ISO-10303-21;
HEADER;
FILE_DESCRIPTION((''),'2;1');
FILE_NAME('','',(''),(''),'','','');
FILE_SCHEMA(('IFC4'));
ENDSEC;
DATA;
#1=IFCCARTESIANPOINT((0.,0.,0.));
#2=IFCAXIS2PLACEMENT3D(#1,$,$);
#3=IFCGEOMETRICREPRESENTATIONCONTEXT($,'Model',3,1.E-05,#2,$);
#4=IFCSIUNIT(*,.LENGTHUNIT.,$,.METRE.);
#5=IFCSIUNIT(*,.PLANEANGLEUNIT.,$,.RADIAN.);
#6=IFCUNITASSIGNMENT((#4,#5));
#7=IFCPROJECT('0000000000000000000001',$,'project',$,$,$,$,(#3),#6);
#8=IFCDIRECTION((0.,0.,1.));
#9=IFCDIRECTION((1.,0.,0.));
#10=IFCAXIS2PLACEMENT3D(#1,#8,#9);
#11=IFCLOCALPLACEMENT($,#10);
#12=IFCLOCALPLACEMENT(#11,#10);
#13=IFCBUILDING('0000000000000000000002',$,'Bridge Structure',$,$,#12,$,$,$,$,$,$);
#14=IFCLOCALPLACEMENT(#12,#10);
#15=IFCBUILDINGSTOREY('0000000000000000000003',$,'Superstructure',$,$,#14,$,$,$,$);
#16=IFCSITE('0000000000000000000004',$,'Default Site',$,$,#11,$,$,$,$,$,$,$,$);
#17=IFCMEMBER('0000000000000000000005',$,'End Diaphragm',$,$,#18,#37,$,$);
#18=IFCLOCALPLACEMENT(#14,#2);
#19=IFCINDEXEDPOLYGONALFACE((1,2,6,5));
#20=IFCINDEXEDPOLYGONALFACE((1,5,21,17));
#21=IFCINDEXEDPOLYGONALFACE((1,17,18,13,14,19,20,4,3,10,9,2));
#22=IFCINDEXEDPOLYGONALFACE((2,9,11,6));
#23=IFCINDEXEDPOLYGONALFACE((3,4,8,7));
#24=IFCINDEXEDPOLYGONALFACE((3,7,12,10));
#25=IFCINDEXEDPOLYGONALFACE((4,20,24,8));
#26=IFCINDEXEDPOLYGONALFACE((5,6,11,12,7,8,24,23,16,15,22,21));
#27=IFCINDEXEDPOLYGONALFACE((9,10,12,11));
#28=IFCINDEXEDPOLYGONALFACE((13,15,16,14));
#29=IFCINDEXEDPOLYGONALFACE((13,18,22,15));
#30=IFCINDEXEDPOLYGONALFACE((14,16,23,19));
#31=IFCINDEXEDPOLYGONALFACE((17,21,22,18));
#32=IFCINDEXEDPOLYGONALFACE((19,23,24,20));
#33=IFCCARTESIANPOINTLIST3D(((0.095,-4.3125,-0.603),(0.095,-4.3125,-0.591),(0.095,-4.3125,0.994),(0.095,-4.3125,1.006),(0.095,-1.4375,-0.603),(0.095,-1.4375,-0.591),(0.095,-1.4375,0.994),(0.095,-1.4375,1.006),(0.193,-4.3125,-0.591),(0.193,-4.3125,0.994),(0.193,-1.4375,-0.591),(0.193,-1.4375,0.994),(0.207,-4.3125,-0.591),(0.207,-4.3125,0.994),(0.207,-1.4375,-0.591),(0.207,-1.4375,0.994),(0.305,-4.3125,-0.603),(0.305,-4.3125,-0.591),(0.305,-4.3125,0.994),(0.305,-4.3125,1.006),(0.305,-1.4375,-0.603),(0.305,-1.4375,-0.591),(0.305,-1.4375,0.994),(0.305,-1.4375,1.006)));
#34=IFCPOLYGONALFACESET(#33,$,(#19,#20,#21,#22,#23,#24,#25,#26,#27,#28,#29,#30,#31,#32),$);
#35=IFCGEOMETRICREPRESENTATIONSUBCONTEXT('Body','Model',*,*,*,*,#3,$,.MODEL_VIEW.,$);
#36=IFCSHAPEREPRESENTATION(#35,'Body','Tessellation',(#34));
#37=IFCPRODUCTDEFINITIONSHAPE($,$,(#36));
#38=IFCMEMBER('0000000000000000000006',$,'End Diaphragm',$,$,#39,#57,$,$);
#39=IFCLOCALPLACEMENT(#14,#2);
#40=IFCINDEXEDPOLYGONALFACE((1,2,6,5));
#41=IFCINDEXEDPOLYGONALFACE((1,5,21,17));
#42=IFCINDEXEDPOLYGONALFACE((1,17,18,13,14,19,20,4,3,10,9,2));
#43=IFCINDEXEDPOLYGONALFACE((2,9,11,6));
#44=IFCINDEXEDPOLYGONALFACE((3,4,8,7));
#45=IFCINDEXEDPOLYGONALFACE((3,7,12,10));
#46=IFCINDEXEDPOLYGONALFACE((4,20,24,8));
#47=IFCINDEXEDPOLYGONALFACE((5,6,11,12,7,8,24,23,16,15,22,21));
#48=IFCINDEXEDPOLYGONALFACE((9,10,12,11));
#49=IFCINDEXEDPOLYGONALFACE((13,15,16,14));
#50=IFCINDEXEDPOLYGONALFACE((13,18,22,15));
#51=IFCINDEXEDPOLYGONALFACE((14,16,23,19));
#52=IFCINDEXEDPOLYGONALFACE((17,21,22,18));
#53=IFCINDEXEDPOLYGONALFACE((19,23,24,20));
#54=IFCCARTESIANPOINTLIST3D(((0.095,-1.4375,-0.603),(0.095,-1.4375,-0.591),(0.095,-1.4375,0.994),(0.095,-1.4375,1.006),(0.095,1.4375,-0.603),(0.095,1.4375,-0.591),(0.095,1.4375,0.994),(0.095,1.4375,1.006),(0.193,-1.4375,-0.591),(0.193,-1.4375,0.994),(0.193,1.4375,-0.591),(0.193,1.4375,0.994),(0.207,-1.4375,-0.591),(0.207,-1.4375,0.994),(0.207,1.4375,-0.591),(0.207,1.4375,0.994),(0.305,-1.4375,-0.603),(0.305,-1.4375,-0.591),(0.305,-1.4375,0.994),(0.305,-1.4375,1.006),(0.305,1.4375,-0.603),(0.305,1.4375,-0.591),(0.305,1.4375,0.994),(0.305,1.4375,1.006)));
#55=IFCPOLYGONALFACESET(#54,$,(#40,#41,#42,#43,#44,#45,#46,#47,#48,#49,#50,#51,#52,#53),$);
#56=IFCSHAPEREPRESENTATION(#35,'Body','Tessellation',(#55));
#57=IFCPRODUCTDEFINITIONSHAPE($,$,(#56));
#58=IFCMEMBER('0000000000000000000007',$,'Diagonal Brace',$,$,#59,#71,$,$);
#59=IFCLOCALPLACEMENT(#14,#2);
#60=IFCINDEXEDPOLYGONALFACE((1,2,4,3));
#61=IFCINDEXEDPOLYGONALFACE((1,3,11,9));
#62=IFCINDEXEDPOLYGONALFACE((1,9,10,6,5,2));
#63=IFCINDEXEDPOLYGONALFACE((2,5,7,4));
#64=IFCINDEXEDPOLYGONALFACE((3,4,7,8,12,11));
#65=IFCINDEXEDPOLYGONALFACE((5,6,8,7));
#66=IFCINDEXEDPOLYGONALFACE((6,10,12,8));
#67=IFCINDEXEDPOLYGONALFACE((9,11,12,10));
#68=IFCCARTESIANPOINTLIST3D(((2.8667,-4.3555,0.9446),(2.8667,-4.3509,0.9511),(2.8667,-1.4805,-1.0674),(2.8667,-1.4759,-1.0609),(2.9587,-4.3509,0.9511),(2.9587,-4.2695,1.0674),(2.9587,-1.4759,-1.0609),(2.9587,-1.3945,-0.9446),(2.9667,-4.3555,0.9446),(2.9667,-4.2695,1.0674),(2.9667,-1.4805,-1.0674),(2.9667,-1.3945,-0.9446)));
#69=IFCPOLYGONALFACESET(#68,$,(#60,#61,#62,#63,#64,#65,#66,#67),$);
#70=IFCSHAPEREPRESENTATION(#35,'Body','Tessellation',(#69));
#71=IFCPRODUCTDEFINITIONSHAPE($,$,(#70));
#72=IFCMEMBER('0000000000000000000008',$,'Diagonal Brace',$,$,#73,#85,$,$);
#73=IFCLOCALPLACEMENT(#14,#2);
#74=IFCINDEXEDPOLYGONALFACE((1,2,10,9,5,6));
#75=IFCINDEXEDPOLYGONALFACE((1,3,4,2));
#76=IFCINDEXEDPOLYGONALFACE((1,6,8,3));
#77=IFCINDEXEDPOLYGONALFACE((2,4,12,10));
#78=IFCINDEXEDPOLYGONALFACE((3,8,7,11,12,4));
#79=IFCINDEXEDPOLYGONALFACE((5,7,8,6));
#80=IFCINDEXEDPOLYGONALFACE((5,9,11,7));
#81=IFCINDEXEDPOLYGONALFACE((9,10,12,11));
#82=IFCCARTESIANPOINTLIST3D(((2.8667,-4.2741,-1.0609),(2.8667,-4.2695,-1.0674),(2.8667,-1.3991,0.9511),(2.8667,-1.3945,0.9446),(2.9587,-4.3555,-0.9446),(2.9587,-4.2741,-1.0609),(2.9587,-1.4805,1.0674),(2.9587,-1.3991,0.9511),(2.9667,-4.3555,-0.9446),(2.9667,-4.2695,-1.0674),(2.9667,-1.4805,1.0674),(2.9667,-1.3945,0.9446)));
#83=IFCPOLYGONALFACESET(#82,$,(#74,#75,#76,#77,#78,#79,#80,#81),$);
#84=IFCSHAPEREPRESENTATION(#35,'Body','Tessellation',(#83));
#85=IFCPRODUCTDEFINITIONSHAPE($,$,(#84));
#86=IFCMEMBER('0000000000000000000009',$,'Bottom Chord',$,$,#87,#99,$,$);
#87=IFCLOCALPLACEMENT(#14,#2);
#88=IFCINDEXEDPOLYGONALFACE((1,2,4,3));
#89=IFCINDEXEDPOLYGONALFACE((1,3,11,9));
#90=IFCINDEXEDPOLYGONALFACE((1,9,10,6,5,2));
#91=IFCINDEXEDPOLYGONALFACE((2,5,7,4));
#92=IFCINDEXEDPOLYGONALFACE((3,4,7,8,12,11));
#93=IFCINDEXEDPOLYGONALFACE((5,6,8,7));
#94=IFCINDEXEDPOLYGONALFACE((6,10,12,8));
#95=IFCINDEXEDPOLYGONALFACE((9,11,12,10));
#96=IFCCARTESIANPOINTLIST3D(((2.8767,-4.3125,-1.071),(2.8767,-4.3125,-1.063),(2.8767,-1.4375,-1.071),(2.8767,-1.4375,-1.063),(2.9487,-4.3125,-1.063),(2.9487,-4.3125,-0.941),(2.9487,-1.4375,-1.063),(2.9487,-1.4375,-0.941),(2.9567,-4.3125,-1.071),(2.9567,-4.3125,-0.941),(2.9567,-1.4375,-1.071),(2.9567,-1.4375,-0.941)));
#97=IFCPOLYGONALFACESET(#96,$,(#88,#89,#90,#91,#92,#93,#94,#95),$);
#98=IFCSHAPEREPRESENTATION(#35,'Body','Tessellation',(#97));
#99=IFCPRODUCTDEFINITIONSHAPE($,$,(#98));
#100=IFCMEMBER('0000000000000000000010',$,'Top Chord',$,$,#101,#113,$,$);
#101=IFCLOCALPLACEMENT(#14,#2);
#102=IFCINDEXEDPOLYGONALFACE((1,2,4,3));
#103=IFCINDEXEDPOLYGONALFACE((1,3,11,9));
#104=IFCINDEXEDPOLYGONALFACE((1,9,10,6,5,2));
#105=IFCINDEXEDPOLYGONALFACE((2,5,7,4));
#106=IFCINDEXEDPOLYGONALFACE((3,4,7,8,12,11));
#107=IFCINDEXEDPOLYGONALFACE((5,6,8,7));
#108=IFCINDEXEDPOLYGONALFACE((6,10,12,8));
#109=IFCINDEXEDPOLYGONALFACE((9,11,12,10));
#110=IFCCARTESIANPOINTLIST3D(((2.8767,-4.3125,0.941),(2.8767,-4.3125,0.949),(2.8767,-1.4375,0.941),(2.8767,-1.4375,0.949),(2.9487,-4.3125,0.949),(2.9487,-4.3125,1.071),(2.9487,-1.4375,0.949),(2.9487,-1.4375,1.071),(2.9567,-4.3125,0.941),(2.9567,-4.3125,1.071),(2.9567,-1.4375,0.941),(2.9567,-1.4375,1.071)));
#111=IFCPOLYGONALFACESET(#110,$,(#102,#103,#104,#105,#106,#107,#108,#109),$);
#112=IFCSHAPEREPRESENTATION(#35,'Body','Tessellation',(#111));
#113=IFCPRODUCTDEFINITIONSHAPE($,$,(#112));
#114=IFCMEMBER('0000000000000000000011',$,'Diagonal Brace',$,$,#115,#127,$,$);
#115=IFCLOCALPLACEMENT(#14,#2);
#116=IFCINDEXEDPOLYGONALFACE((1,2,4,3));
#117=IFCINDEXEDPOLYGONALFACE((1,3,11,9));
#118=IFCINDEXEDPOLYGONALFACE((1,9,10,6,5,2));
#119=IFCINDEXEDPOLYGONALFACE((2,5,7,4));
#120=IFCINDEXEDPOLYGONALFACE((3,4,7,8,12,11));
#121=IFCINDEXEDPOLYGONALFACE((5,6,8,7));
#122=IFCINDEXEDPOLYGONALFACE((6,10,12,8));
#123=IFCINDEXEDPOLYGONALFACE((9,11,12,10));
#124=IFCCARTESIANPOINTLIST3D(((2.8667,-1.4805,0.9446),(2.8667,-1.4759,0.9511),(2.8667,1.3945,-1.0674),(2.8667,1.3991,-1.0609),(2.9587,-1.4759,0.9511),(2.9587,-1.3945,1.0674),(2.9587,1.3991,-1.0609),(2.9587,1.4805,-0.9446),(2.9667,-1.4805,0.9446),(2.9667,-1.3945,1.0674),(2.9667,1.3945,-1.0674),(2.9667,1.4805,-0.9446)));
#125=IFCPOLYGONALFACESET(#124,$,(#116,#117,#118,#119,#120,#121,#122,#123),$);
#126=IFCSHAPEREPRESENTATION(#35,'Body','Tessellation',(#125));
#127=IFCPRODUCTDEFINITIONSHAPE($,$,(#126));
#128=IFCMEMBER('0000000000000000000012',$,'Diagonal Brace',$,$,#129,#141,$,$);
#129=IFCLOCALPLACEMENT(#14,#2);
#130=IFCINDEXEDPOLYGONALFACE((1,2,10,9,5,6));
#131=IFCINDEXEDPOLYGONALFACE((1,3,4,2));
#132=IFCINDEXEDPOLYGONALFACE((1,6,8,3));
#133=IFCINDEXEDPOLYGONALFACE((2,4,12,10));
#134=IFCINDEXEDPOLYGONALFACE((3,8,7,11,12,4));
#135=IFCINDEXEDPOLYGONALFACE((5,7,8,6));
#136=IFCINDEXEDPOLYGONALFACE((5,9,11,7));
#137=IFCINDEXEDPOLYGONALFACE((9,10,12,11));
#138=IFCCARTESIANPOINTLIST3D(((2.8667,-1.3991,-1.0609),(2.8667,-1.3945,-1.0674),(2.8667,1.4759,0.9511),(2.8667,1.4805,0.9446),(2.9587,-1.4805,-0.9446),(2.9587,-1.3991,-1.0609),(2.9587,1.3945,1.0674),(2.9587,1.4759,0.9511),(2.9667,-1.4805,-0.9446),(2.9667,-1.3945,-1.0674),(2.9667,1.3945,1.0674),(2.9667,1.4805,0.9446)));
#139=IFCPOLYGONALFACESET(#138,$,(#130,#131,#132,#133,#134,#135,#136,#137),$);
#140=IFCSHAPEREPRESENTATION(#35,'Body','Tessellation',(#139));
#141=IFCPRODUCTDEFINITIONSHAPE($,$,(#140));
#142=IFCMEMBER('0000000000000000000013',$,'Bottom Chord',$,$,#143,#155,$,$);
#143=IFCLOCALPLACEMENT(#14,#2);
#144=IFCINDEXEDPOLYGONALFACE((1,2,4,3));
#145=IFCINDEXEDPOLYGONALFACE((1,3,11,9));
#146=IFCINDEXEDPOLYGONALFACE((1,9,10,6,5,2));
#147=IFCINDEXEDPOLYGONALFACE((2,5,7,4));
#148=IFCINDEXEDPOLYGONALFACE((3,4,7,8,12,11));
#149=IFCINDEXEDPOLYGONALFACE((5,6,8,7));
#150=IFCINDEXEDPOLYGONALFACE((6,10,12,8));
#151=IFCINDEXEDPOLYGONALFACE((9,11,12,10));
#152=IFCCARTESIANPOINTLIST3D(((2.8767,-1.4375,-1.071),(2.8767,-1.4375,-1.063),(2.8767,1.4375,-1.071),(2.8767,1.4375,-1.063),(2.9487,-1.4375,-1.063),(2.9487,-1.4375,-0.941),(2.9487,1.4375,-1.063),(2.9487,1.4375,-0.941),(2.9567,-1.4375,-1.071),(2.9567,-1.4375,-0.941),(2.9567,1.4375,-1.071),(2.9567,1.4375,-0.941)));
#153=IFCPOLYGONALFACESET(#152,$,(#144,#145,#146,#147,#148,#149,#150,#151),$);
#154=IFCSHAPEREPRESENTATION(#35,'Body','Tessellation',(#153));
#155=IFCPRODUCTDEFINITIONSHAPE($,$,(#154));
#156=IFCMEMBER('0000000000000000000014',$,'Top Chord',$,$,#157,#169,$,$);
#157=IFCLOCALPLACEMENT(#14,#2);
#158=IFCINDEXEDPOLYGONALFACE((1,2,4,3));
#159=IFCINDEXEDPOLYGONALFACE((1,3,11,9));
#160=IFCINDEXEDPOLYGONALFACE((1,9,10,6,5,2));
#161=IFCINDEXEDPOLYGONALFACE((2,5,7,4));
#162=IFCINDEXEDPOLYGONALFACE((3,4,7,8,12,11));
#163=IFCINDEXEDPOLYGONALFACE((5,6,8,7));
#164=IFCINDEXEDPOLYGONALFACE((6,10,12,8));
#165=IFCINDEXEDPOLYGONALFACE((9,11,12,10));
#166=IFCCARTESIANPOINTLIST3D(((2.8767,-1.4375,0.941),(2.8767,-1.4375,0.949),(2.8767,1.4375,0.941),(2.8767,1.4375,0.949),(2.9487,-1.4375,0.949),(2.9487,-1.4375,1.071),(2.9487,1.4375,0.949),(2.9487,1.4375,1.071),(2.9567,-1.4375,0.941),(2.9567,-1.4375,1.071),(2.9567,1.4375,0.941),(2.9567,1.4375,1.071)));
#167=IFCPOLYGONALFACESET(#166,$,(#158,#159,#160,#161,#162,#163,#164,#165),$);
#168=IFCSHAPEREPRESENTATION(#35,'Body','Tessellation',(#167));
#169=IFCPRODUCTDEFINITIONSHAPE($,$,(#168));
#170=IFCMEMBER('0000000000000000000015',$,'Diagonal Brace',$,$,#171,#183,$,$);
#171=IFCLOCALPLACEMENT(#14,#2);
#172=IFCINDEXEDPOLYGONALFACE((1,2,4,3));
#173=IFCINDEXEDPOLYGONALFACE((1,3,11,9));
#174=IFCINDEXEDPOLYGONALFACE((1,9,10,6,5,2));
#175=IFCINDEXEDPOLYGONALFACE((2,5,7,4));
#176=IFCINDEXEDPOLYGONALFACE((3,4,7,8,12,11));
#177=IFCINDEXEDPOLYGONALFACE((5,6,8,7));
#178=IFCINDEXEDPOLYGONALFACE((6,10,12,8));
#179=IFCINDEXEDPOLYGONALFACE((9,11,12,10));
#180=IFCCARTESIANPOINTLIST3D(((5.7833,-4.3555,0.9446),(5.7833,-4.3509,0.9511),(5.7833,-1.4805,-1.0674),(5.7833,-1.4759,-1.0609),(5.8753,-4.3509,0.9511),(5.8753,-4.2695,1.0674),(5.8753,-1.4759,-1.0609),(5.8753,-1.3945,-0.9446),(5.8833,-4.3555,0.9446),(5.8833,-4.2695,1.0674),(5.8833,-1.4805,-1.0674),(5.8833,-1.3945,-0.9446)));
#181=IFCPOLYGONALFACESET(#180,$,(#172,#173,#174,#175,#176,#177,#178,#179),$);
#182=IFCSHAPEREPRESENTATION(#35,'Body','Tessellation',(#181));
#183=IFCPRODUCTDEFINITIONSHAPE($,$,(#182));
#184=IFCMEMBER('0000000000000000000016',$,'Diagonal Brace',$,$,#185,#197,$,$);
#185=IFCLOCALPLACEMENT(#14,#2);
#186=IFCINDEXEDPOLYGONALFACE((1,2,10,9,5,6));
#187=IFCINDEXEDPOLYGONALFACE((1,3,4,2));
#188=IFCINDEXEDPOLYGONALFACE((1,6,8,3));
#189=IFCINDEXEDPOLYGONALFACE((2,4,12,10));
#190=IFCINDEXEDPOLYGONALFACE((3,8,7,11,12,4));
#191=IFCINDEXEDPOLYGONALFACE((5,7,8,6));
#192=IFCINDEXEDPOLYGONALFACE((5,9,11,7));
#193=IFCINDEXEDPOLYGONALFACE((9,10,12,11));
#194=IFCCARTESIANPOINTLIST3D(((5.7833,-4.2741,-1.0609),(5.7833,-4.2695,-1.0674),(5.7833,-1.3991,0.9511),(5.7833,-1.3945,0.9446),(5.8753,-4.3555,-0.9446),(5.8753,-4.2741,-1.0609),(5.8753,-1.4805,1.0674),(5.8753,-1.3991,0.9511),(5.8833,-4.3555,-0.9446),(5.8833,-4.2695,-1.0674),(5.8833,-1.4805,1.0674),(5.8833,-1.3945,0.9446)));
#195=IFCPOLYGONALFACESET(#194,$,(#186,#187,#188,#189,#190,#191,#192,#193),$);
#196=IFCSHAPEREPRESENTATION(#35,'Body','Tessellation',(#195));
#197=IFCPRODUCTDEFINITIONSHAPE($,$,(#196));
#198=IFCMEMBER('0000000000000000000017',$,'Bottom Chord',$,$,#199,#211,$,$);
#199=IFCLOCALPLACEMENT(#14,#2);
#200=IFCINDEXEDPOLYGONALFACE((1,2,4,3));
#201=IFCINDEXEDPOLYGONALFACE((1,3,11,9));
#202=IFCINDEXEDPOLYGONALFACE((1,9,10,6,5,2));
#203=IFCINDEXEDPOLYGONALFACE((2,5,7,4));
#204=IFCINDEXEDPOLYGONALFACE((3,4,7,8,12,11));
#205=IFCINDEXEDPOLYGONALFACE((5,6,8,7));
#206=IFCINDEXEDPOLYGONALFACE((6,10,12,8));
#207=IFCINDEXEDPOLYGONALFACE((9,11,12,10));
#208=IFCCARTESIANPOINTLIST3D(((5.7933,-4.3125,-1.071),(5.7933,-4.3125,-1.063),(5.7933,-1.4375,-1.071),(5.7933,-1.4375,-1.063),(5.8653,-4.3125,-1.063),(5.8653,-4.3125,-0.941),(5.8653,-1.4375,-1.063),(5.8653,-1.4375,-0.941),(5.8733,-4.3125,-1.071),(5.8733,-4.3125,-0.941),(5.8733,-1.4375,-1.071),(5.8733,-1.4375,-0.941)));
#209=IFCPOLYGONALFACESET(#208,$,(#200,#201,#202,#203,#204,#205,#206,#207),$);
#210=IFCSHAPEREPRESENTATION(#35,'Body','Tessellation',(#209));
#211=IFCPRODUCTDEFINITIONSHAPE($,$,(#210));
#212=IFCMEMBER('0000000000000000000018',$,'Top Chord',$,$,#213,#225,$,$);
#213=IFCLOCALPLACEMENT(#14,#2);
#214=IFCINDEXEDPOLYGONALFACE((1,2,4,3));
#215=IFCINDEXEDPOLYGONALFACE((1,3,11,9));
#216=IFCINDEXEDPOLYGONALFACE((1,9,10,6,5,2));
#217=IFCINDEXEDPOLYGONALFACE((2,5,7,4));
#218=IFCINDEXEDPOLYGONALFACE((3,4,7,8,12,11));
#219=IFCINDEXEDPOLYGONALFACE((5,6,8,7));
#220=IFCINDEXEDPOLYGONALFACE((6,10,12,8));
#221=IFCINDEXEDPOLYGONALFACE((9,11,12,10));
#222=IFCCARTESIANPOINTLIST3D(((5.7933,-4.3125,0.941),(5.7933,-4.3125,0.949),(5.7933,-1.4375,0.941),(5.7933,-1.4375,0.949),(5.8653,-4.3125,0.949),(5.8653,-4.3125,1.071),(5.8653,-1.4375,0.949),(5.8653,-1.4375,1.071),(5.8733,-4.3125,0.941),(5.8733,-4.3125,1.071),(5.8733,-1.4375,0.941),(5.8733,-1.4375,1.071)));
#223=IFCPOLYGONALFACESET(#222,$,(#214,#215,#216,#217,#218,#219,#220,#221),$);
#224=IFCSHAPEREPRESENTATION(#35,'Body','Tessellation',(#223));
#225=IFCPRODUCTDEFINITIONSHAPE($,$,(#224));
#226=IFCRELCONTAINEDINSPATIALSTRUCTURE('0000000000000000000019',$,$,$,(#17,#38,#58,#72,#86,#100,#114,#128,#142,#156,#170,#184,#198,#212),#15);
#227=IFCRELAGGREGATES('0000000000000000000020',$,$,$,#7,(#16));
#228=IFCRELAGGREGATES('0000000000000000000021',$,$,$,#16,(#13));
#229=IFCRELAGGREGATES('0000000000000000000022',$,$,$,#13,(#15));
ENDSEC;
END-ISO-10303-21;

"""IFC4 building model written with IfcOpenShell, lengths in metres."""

from ifc_helpers import new_model, si_unit, frame, origin, origin_with_axes, origin_2d_with_axis, place, context, subcontext, project, spatial, i_section, l_section, extrude, element, save


model = new_model("IFC4")

# Units and contexts
model_context = context("Model", 3, precision=1e-05, world=origin())
body_context = subcontext(model_context, "Body", "Model", "MODEL_VIEW")
ifc_project = project(units=[si_unit("LENGTHUNIT", "METRE"), si_unit("PLANEANGLEUNIT", "RADIAN")], contexts=[model_context])

# Site, building, storey
site_placement = place(None, origin_with_axes())
site = spatial("IfcSite", under=ifc_project, at=site_placement, Name="Default Site")
building_placement = place(site_placement, origin_with_axes())
building = spatial("IfcBuilding", under=site, at=building_placement, Name="Bridge Structure")
storey_placement = place(building_placement, origin_with_axes())
storey = spatial("IfcBuildingStorey", under=building, at=storey_placement, Name="Superstructure")

# Members
for number, where, z_axis, x_axis, name in (
    (1, (0.2, -4.3125, 0.2015), (0.0, 1.0, 0.0), (-1.0, 0.0, 0.0), "End Diaphragm"),
    (2, (0.2, -1.4375, 0.2015), (0.0, 1.0, 0.0), (-1.0, 0.0, 0.0), "End Diaphragm"),
):
    element("IfcMember", number, at=place(storey_placement, frame(where, z_axis=z_axis, x_axis=x_axis)), inside=storey, Name=name, context=body_context, shape_type="SweptSolid", body=[
        extrude(i_section(OverallWidth=0.21, OverallDepth=1.609, WebThickness=0.014, FlangeThickness=0.012, at=origin_2d_with_axis()), origin_with_axes(), (0.0, 0.0, 1.0), 2.875),
    ])
for number, where, z_axis, x_axis, name in (
    (3, (2.9167, -4.3125, 1.006), (0.0, 0.819299, -0.573367), (-1.0, 0.0, 0.0), "Diagonal Brace"),
    (4, (2.9167, -4.3125, -1.006), (0.0, 0.819299, 0.573367), (-1.0, 0.0, 0.0), "Diagonal Brace"),
):
    element("IfcMember", number, at=place(storey_placement, frame(where, z_axis=z_axis, x_axis=x_axis)), inside=storey, Name=name, context=body_context, shape_type="SweptSolid", body=[
        extrude(l_section(Depth=0.15, Width=0.1, Thickness=0.008, at=origin_2d_with_axis()), origin_with_axes(), (0.0, 0.0, 1.0), 3.5091),
    ])
for number, where, z_axis, x_axis, name in (
    (5, (2.9167, -4.3125, -1.006), (0.0, 1.0, 0.0), (-1.0, 0.0, 0.0), "Bottom Chord"),
    (6, (2.9167, -4.3125, 1.006), (0.0, 1.0, 0.0), (-1.0, 0.0, 0.0), "Top Chord"),
):
    element("IfcMember", number, at=place(storey_placement, frame(where, z_axis=z_axis, x_axis=x_axis)), inside=storey, Name=name, context=body_context, shape_type="SweptSolid", body=[
        extrude(l_section(Depth=0.13, Width=0.08, Thickness=0.008, at=origin_2d_with_axis()), origin_with_axes(), (0.0, 0.0, 1.0), 2.875),
    ])
for number, where, z_axis, x_axis, name in (
    (7, (2.9167, -1.4375, 1.006), (0.0, 0.819299, -0.573367), (-1.0, 0.0, 0.0), "Diagonal Brace"),
    (8, (2.9167, -1.4375, -1.006), (0.0, 0.819299, 0.573367), (-1.0, 0.0, 0.0), "Diagonal Brace"),
):
    element("IfcMember", number, at=place(storey_placement, frame(where, z_axis=z_axis, x_axis=x_axis)), inside=storey, Name=name, context=body_context, shape_type="SweptSolid", body=[
        extrude(l_section(Depth=0.15, Width=0.1, Thickness=0.008, at=origin_2d_with_axis()), origin_with_axes(), (0.0, 0.0, 1.0), 3.5091),
    ])
for number, where, z_axis, x_axis, name in (
    (9, (2.9167, -1.4375, -1.006), (0.0, 1.0, 0.0), (-1.0, 0.0, 0.0), "Bottom Chord"),
    (10, (2.9167, -1.4375, 1.006), (0.0, 1.0, 0.0), (-1.0, 0.0, 0.0), "Top Chord"),
):
    element("IfcMember", number, at=place(storey_placement, frame(where, z_axis=z_axis, x_axis=x_axis)), inside=storey, Name=name, context=body_context, shape_type="SweptSolid", body=[
        extrude(l_section(Depth=0.13, Width=0.08, Thickness=0.008, at=origin_2d_with_axis()), origin_with_axes(), (0.0, 0.0, 1.0), 2.875),
    ])
for number, where, z_axis, x_axis, name in (
    (11, (5.8333, -4.3125, 1.006), (0.0, 0.819299, -0.573367), (-1.0, 0.0, 0.0), "Diagonal Brace"),
    (12, (5.8333, -4.3125, -1.006), (0.0, 0.819299, 0.573367), (-1.0, 0.0, 0.0), "Diagonal Brace"),
):
    element("IfcMember", number, at=place(storey_placement, frame(where, z_axis=z_axis, x_axis=x_axis)), inside=storey, Name=name, context=body_context, shape_type="SweptSolid", body=[
        extrude(l_section(Depth=0.15, Width=0.1, Thickness=0.008, at=origin_2d_with_axis()), origin_with_axes(), (0.0, 0.0, 1.0), 3.5091),
    ])
for number, where, z_axis, x_axis, name in (
    (13, (5.8333, -4.3125, -1.006), (0.0, 1.0, 0.0), (-1.0, 0.0, 0.0), "Bottom Chord"),
    (14, (5.8333, -4.3125, 1.006), (0.0, 1.0, 0.0), (-1.0, 0.0, 0.0), "Top Chord"),
):
    element("IfcMember", number, at=place(storey_placement, frame(where, z_axis=z_axis, x_axis=x_axis)), inside=storey, Name=name, context=body_context, shape_type="SweptSolid", body=[
        extrude(l_section(Depth=0.13, Width=0.08, Thickness=0.008, at=origin_2d_with_axis()), origin_with_axes(), (0.0, 0.0, 1.0), 2.875),
    ])

save(model, "model.ifc")
